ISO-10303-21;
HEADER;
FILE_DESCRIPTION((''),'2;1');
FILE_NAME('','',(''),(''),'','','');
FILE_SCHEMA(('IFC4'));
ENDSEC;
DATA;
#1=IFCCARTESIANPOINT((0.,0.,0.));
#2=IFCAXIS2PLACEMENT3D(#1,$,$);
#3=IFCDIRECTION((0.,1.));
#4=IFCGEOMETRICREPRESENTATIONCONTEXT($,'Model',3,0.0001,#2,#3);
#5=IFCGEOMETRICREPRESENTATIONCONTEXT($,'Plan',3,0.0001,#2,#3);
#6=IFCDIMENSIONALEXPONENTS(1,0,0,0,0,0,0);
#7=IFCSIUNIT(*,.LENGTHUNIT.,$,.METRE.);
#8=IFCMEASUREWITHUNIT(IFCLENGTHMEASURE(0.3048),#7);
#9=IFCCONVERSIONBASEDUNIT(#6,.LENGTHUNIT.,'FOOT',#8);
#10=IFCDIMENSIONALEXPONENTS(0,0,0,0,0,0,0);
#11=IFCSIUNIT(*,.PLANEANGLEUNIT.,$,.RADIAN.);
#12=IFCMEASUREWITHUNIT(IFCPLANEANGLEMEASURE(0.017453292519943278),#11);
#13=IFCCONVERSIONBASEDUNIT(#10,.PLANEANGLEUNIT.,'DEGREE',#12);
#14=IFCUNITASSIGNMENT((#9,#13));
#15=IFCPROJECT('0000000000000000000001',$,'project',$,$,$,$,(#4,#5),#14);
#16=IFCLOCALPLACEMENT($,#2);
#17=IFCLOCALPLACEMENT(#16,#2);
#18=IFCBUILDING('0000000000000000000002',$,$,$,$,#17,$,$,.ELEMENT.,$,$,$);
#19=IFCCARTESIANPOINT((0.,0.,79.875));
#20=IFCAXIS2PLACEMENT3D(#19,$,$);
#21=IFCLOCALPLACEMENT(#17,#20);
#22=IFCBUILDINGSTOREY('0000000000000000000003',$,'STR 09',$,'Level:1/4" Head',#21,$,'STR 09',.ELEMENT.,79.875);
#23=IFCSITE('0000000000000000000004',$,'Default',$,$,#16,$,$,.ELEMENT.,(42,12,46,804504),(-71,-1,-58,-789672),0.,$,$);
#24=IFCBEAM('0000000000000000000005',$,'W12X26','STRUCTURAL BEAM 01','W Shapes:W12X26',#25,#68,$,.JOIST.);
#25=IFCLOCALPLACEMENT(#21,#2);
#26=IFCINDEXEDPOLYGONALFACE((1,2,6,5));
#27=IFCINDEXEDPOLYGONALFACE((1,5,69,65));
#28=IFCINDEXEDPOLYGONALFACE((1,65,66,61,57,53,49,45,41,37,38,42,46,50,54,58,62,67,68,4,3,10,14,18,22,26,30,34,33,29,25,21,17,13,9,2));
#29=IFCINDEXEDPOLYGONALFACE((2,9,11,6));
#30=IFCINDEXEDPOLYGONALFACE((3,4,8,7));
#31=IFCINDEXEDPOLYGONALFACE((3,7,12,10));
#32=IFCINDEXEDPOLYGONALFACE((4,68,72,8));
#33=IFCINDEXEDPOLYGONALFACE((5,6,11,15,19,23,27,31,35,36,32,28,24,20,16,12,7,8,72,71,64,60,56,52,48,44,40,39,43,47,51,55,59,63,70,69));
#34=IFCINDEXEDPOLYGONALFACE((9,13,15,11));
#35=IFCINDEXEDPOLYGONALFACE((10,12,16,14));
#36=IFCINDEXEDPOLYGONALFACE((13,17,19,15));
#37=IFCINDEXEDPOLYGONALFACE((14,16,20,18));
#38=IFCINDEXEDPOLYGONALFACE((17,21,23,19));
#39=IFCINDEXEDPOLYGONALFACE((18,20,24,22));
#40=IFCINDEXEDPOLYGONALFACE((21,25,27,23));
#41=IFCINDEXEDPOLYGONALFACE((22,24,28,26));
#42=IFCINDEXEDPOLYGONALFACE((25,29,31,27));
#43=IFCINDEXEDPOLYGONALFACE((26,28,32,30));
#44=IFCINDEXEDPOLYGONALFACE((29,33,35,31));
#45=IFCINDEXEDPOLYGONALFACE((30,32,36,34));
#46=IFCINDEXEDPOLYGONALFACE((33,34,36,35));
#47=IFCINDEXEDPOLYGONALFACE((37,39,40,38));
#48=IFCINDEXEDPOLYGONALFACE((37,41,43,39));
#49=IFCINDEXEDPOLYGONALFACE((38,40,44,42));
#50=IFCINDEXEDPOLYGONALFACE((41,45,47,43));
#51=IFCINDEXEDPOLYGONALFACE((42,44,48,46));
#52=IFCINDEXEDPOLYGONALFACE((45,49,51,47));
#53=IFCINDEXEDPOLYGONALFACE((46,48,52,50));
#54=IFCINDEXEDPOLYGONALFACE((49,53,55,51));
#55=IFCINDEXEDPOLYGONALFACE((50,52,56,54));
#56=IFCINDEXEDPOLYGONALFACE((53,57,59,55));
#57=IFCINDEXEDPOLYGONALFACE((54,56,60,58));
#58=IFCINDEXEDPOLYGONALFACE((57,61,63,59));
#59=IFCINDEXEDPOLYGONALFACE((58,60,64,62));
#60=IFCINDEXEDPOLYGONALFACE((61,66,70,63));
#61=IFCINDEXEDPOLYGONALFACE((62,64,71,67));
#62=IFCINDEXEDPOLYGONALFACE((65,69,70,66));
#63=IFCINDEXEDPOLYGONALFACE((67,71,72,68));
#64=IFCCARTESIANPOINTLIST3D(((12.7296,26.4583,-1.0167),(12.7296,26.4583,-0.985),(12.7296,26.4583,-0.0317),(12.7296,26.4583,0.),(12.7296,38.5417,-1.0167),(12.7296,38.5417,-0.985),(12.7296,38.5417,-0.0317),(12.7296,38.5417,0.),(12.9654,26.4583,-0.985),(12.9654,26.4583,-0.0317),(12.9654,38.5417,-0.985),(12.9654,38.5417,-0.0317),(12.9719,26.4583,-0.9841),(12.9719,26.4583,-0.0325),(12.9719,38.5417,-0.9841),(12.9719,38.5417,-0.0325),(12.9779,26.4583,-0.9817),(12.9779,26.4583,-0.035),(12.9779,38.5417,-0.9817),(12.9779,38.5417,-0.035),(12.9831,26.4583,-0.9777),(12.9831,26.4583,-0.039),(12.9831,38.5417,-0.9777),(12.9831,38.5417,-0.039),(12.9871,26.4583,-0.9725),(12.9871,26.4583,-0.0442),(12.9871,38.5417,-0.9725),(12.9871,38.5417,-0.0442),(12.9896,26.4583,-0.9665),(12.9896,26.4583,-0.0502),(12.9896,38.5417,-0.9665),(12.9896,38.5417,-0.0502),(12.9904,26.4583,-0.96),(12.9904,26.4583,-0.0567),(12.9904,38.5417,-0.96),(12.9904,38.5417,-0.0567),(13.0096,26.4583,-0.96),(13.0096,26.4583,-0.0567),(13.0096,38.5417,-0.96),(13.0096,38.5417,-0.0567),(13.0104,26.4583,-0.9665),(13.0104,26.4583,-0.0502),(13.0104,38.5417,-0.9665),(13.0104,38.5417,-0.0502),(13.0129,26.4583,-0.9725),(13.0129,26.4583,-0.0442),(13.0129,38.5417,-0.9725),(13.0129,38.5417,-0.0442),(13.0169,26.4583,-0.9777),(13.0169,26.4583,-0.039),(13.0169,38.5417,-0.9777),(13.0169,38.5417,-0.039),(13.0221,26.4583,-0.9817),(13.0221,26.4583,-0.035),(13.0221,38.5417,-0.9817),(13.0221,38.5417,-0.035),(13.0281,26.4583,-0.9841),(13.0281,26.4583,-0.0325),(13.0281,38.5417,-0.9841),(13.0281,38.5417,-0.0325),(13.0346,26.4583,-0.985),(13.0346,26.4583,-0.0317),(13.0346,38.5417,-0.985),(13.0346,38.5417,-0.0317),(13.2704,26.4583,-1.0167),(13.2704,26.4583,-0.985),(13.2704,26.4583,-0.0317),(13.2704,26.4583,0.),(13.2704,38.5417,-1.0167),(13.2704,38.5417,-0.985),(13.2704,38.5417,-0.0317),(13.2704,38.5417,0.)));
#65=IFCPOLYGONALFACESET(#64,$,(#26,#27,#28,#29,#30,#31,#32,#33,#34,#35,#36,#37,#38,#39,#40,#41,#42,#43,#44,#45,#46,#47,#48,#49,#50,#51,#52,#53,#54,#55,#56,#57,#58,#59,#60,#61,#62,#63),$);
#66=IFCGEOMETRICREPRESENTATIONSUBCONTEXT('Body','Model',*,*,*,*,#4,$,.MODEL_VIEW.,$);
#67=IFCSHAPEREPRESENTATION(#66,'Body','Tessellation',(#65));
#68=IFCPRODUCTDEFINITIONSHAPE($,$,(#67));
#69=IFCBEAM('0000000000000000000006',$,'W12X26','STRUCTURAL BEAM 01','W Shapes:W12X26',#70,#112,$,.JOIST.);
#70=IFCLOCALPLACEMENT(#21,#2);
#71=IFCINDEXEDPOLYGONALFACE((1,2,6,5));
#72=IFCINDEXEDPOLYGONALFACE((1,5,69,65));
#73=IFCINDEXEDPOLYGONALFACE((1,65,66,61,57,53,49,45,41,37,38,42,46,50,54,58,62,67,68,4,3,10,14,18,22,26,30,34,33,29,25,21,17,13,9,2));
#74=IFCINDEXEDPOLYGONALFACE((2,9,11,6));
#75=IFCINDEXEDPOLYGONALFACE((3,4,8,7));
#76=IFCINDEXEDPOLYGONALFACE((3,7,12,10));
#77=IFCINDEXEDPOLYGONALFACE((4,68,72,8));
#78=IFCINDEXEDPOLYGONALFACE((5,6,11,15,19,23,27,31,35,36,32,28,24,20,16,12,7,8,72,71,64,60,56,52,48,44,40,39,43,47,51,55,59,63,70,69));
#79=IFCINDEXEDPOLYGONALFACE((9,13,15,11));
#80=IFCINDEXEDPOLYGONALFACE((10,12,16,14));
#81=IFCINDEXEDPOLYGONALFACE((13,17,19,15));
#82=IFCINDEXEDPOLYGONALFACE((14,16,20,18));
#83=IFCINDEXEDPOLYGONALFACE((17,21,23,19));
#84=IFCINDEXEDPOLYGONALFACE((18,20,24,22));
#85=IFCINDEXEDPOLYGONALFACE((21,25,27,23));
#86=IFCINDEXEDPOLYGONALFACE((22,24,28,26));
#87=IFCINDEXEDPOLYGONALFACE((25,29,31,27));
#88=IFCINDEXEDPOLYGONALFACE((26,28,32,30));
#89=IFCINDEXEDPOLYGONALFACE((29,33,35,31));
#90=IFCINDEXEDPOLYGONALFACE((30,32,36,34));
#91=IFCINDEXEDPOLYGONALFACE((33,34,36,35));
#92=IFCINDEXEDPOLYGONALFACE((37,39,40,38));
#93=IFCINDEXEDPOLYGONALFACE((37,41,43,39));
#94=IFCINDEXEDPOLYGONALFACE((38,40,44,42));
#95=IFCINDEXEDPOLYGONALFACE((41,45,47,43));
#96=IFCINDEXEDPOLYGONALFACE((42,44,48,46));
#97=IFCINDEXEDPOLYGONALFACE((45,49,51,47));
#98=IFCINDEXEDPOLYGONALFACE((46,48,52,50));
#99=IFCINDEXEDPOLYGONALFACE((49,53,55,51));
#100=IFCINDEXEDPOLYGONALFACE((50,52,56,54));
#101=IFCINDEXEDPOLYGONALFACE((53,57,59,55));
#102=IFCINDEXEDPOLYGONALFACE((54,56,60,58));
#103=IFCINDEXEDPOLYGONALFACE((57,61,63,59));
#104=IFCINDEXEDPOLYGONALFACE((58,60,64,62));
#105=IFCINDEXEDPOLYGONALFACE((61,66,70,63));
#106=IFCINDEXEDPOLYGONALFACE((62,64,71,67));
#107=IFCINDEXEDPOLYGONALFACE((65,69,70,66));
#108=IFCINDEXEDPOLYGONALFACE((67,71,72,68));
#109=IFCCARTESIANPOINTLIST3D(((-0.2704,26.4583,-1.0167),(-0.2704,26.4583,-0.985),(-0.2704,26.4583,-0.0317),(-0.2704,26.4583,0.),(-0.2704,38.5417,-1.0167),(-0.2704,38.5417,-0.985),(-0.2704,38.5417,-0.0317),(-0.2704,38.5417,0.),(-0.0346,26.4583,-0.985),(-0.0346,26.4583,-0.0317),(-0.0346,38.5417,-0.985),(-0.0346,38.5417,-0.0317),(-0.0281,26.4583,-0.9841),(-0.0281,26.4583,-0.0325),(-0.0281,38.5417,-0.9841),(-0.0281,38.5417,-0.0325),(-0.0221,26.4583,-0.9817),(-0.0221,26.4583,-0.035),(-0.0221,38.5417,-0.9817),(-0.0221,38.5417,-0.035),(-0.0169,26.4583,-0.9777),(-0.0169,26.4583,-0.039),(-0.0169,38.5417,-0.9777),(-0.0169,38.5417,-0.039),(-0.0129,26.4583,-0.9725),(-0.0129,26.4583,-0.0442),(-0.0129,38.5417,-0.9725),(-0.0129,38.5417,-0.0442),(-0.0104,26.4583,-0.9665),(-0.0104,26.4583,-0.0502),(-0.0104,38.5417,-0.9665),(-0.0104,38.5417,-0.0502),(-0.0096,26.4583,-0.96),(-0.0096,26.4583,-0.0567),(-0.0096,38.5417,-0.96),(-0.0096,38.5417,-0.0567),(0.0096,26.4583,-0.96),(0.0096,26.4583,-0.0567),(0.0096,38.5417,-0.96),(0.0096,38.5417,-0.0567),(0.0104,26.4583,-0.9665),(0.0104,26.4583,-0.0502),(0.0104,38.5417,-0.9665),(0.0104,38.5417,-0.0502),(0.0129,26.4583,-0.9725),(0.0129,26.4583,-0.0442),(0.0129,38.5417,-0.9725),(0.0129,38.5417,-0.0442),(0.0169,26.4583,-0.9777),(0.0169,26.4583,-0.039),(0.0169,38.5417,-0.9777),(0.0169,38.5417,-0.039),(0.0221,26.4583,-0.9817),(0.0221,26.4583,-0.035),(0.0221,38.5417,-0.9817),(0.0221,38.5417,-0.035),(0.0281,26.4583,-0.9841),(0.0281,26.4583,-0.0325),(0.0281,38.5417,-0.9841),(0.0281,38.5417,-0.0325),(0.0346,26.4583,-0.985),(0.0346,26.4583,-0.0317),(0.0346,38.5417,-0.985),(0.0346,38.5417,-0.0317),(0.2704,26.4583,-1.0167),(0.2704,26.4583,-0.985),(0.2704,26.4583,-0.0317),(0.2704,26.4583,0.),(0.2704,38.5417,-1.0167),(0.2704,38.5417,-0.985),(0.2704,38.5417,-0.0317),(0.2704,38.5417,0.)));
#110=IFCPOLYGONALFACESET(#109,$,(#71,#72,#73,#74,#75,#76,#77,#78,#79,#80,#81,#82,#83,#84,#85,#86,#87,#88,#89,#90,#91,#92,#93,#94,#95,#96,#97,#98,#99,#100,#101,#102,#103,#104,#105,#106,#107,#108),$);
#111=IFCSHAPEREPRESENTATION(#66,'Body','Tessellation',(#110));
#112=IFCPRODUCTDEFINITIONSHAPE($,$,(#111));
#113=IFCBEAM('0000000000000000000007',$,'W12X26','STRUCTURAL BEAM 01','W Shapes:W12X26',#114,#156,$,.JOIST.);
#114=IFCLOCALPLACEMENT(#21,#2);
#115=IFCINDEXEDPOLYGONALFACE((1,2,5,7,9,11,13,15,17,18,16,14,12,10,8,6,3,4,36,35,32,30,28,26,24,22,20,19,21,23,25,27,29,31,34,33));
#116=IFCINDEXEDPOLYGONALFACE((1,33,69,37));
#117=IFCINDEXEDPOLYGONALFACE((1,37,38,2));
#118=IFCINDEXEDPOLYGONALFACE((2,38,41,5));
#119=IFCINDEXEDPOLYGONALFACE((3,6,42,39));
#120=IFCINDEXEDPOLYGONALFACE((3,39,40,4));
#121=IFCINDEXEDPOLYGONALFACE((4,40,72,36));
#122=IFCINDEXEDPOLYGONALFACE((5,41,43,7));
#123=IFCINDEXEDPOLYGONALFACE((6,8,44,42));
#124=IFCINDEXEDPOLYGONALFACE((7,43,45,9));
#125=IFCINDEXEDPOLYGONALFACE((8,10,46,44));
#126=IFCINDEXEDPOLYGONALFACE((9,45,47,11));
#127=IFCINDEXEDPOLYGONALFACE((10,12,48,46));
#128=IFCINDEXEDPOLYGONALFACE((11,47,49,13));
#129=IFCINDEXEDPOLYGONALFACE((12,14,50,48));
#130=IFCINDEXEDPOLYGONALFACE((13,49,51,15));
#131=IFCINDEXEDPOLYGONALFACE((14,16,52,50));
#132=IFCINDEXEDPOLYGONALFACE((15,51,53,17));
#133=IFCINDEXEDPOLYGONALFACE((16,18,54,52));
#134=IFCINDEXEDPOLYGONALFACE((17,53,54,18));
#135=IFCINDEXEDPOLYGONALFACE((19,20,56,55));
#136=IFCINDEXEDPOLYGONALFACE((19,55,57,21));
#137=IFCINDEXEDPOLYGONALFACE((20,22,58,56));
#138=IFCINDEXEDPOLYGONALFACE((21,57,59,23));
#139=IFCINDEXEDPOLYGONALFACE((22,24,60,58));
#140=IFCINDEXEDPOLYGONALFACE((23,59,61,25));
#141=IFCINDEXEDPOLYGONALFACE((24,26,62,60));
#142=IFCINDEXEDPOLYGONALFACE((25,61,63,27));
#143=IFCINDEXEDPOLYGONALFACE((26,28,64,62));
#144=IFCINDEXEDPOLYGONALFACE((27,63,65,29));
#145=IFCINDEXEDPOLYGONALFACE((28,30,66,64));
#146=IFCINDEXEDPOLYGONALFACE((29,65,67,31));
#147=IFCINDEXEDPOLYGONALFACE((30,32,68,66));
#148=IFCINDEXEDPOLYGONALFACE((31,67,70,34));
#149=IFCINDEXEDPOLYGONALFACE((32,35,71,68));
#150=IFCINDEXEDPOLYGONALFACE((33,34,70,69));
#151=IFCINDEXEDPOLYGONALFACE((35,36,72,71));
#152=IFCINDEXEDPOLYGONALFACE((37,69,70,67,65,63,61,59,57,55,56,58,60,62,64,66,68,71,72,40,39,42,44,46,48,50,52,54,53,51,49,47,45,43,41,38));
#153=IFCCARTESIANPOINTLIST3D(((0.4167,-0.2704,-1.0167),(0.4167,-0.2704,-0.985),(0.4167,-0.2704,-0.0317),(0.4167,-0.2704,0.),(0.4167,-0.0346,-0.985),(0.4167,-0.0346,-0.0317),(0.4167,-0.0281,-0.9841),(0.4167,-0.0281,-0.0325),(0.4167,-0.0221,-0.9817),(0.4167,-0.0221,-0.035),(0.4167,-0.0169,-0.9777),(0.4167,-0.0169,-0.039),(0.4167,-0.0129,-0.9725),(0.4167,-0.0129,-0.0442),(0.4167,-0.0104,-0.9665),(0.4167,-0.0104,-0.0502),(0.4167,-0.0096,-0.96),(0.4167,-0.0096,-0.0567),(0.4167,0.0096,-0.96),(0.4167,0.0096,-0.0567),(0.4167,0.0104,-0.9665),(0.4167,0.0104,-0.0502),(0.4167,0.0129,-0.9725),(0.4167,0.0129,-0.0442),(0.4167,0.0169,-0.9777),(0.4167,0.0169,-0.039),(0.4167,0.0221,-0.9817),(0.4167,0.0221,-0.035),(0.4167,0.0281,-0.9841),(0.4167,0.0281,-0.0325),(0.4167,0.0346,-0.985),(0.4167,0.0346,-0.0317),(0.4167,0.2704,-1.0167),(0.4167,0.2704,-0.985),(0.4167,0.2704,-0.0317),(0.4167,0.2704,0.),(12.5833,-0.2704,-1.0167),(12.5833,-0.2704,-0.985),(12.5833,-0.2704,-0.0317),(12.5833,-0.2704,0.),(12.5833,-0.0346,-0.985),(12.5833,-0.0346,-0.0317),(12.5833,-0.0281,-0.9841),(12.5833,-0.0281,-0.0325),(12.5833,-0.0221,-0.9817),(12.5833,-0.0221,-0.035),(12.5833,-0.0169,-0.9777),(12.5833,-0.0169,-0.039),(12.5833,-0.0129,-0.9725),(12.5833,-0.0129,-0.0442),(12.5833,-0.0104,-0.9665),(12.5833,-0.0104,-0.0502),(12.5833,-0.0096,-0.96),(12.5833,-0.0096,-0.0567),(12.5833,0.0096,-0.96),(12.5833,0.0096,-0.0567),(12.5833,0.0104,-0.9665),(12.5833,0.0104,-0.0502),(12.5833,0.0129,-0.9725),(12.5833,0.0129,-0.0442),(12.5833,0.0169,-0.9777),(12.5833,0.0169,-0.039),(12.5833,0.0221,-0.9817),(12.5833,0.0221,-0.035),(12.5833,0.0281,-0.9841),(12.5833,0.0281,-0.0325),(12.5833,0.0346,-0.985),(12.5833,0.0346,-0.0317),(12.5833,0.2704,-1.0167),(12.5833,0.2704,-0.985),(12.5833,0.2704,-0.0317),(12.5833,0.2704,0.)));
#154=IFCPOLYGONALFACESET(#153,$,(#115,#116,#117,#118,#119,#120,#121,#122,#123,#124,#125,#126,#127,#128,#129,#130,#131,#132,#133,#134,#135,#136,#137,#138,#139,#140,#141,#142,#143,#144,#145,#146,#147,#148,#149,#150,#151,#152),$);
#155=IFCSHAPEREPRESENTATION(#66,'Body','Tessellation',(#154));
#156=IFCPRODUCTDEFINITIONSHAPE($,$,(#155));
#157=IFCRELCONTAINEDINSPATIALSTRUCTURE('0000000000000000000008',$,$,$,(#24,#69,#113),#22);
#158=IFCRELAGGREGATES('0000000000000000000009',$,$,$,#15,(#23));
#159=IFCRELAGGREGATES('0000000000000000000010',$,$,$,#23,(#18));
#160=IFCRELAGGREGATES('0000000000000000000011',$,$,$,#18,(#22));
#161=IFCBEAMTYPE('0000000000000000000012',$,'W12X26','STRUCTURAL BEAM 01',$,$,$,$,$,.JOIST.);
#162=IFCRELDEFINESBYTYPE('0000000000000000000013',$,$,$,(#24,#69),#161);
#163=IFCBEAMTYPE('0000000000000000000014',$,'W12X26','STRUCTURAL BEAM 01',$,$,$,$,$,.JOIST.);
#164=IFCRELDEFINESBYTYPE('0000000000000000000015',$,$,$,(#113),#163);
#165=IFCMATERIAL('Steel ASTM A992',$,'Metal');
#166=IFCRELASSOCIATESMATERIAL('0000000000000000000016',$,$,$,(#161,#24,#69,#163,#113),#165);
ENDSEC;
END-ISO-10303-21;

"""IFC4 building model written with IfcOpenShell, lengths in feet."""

from ifc_helpers import new_model, entity, si_unit, converted_unit, direction, frame, origin, place, context, subcontext, project, spatial, line, arc, indexed_curve, outline, extrude, source, transform, mapped, material, type_object, type_shapes, element, save


model = new_model("IFC4")

# Units and contexts
model_context = context("Model", 3, precision=0.0001, world=origin(), true_north=direction((0.0, 1.0)))
plan_context = context("Plan", 3, precision=0.0001, world=origin(), true_north=direction((0.0, 1.0)))
body_context = subcontext(model_context, "Body", "Model", "MODEL_VIEW")
ifc_project = project(units=[converted_unit("LENGTHUNIT", "FOOT", entity("IfcLengthMeasure", 0.3048), si_unit("LENGTHUNIT", "METRE"), dimensions=[1, 0, 0, 0, 0, 0, 0]), converted_unit("PLANEANGLEUNIT", "DEGREE", entity("IfcPlaneAngleMeasure", 0.017453292519943278), si_unit("PLANEANGLEUNIT", "RADIAN"), dimensions=[0, 0, 0, 0, 0, 0, 0])], contexts=[model_context, plan_context])

# Site, building, storey
site_placement = place(None, origin())
site = spatial("IfcSite", under=ifc_project, at=site_placement, Name="Default", CompositionType="ELEMENT", RefLatitude=(42, 12, 46, 804504), RefLongitude=(-71, -1, -58, -789672), RefElevation=0.0)
building_placement = place(site_placement, origin())
building = spatial("IfcBuilding", under=site, at=building_placement, CompositionType="ELEMENT")
storey_placement = place(building_placement, frame((0.0, 0.0, 79.875)))
storey = spatial("IfcBuildingStorey", under=building, at=storey_placement, Name="STR 09", ObjectType="Level:1/4\" Head", LongName="STR 09", CompositionType="ELEMENT", Elevation=79.875)

# Beams
ifc_material = material(Name="Steel ASTM A992", Category="Metal")
beam_type_1 = type_object("IfcBeamType", Name="W12X26", Description="STRUCTURAL BEAM 01", PredefinedType="JOIST", material=ifc_material)
shared_shape_1 = source(origin(), body_context, "Body", "SweptSolid", [
    extrude(outline(indexed_curve([(-0.2704, -0.4767), (-0.2704, -0.5083), (0.2704, -0.5083), (0.2704, -0.4767), (0.0346, -0.4767), (0.0169, -0.4693), (0.0096, -0.4517), (0.0096, 0.4517), (0.0169, 0.4693), (0.0346, 0.4767), (0.2704, 0.4767), (0.2704, 0.5083), (-0.2704, 0.5083), (-0.2704, 0.4767), (-0.0346, 0.4767), (-0.0169, 0.4693), (-0.0096, 0.4517), (-0.0096, -0.4517), (-0.0169, -0.4693), (-0.0346, -0.4767)], segments=[line(1, 2, 3, 4, 5), arc(5, 6, 7), line(7, 8), arc(8, 9, 10), line(10, 11, 12, 13, 14, 15), arc(15, 16, 17), line(17, 18), arc(18, 19, 20), line(20, 1)], self_intersect=False)), frame((-6.165, 0.0, 0.0), z_axis=(-1.0, 0.0, 0.0), x_axis=(0.0, -1.0, 0.0)), (0.0, 0.0, -1.0), 12.0833),
])
type_shapes(beam_type_1, [shared_shape_1])
for number, where, z_axis, x_axis, name in (
    (1, (13.0, 32.6234, -0.5083), (0.0, 0.0, 1.0), (0.0, 1.0, 0.0), "W12X26"),
    (2, (0.0, 32.6234, -0.5083), (0.0, 0.0, 1.0), (0.0, 1.0, 0.0), "W12X26"),
):
    element("IfcBeam", number, at=place(storey_placement, frame(where, z_axis=z_axis, x_axis=x_axis)), inside=storey, type_object=beam_type_1, material=ifc_material, Name=name, Description="STRUCTURAL BEAM 01", ObjectType="W Shapes:W12X26", PredefinedType="JOIST", context=body_context, shape_type="MappedRepresentation", body=[
        mapped(shared_shape_1, transform((0.0, 0.0, 0.0), scale=1.0)),
    ])
beam_type_2 = type_object("IfcBeamType", Name="W12X26", Description="STRUCTURAL BEAM 01", PredefinedType="JOIST", material=ifc_material)
shared_shape_2 = source(origin(), body_context, "Body", "SweptSolid", [
    extrude(outline(indexed_curve([(0.4767, -0.2704), (0.5083, -0.2704), (0.5083, 0.2704), (0.4767, 0.2704), (0.4767, 0.0346), (0.4693, 0.0169), (0.4517, 0.0096), (-0.4517, 0.0096), (-0.4693, 0.0169), (-0.4767, 0.0346), (-0.4767, 0.2704), (-0.5083, 0.2704), (-0.5083, -0.2704), (-0.4767, -0.2704), (-0.4767, -0.0346), (-0.4693, -0.0169), (-0.4517, -0.0096), (0.4517, -0.0096), (0.4693, -0.0169), (0.4767, -0.0346)], segments=[line(1, 2, 3, 4, 5), arc(5, 6, 7), line(7, 8), arc(8, 9, 10), line(10, 11, 12, 13, 14, 15), arc(15, 16, 17), line(17, 18), arc(18, 19, 20), line(20, 1)], self_intersect=False)), frame((-6.0833, 0.0, 0.0), z_axis=(1.0, 0.0, 0.0), x_axis=(0.0, 0.0, -1.0)), (0.0, 0.0, 1.0), 12.1667),
])
type_shapes(beam_type_2, [shared_shape_2])
beam_1_placement = place(storey_placement, frame((6.5, 0.0, -0.5083), z_axis=(0.0, 0.0, 1.0), x_axis=(-1.0, 0.0, 0.0)))
element("IfcBeam", 3, at=beam_1_placement, inside=storey, type_object=beam_type_2, material=ifc_material, Name="W12X26", Description="STRUCTURAL BEAM 01", ObjectType="W Shapes:W12X26", PredefinedType="JOIST", context=body_context, shape_type="MappedRepresentation", body=[
    mapped(shared_shape_2, transform((0.0, 0.0, 0.0), scale=1.0)),
])

save(model, "model.ifc")
